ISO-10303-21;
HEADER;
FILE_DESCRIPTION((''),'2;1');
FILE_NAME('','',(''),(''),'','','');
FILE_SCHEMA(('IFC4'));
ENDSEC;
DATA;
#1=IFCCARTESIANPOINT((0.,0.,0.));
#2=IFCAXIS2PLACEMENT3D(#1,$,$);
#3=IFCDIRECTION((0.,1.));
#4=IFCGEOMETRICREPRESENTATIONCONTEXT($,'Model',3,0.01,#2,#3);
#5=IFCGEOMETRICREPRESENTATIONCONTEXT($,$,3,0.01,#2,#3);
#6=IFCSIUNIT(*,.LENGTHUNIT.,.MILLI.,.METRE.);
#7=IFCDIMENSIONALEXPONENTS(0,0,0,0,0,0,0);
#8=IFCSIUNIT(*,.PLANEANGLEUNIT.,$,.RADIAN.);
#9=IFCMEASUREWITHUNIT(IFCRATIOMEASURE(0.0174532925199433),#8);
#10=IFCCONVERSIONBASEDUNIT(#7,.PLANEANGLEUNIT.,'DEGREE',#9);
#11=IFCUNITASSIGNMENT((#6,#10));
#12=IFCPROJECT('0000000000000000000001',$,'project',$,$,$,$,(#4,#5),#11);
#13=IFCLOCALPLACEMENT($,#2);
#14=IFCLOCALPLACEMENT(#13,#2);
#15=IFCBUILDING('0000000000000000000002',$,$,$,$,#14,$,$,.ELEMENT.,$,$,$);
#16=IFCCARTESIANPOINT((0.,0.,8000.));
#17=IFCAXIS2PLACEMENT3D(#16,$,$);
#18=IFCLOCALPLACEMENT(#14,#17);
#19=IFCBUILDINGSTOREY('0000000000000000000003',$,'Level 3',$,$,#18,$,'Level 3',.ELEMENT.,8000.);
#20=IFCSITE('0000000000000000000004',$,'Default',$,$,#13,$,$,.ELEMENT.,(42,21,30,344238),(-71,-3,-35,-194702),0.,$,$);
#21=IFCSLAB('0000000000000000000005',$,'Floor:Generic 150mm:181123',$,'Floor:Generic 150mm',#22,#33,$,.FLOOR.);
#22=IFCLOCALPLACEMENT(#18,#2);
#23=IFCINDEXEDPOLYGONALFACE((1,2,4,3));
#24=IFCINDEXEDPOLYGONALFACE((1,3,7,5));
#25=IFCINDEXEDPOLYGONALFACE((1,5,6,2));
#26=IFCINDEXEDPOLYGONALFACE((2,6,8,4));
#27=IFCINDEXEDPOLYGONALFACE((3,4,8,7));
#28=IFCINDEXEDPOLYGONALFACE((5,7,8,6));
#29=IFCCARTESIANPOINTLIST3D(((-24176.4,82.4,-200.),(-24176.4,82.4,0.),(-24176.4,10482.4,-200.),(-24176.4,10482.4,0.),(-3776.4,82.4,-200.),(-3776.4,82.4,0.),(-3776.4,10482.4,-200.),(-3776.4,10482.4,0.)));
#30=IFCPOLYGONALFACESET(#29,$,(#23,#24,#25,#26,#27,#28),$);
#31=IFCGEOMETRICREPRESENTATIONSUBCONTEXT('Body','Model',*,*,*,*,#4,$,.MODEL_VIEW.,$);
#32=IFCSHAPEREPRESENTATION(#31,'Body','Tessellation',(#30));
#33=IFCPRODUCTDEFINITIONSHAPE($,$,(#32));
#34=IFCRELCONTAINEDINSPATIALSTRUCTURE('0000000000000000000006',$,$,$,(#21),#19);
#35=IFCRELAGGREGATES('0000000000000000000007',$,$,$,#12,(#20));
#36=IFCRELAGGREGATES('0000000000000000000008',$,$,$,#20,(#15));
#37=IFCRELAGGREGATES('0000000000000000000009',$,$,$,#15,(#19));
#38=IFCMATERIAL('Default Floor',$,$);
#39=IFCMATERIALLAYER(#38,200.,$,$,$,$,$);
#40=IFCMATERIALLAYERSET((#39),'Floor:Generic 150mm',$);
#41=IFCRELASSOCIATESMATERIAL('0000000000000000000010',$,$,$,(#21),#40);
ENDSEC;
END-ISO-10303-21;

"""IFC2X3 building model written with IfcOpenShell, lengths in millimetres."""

from ifc_helpers import new_model, entity, si_unit, converted_unit, direction, frame, frame_2d, origin, place, context, subcontext, project, spatial, rectangle, extrude, material, layer, layer_set, layer_usage, element, save


model = new_model("IFC2X3")

# Units and contexts
model_context = context("Model", 3, precision=0.01, world=origin(), true_north=direction((0.0, 1.0)))
context_of_model = context(None, 3, precision=0.01, world=origin(), true_north=direction((0.0, 1.0)))
body_context = subcontext(model_context, "Body", "Model", "MODEL_VIEW")
ifc_project = project(units=[si_unit("LENGTHUNIT", "METRE", prefix="MILLI"), converted_unit("PLANEANGLEUNIT", "DEGREE", entity("IfcRatioMeasure", 0.0174532925199433), si_unit("PLANEANGLEUNIT", "RADIAN"), dimensions=[0, 0, 0, 0, 0, 0, 0])], contexts=[model_context, context_of_model])

# Site, building, storey
site_placement = place(None, origin())
site = spatial("IfcSite", under=ifc_project, at=site_placement, Name="Default", CompositionType="ELEMENT", RefLatitude=(42, 21, 30, 344238), RefLongitude=(-71, -3, -35, -194702), RefElevation=0.0)
building_placement = place(site_placement, origin())
building = spatial("IfcBuilding", under=site, at=building_placement, CompositionType="ELEMENT")
storey_placement = place(building_placement, frame((0.0, 0.0, 8000.0)))
storey = spatial("IfcBuildingStorey", under=building, at=storey_placement, Name="Level 3", LongName="Level 3", CompositionType="ELEMENT", Elevation=8000.0)

# Slab
ifc_material = material(Name="Default Floor")
ifc_layer = layer(ifc_material, 200.0)
ifc_layer_set = layer_set([ifc_layer], Name="Floor:Generic 150mm")
ifc_layer_usage = layer_usage(ifc_layer_set, "AXIS3", "POSITIVE", 0.0)
slab_placement = place(storey_placement, origin())
element("IfcSlab", 1, at=slab_placement, inside=storey, material=ifc_layer_usage, Name="Floor:Generic 150mm:181123", ObjectType="Floor:Generic 150mm", PredefinedType="FLOOR", context=body_context, shape_type="SweptSolid", body=[
    extrude(rectangle(XDim=10400.0, YDim=20400.0, at=frame_2d((0.0, 0.0), x_axis=(1.0, 0.0))), frame((-13976.4, 5282.4, 0.0), z_axis=(0.0, 0.0, -1.0), x_axis=(0.0, 1.0, 0.0)), (0.0, 0.0, 1.0), 200.0),
])

save(model, "model.ifc")
